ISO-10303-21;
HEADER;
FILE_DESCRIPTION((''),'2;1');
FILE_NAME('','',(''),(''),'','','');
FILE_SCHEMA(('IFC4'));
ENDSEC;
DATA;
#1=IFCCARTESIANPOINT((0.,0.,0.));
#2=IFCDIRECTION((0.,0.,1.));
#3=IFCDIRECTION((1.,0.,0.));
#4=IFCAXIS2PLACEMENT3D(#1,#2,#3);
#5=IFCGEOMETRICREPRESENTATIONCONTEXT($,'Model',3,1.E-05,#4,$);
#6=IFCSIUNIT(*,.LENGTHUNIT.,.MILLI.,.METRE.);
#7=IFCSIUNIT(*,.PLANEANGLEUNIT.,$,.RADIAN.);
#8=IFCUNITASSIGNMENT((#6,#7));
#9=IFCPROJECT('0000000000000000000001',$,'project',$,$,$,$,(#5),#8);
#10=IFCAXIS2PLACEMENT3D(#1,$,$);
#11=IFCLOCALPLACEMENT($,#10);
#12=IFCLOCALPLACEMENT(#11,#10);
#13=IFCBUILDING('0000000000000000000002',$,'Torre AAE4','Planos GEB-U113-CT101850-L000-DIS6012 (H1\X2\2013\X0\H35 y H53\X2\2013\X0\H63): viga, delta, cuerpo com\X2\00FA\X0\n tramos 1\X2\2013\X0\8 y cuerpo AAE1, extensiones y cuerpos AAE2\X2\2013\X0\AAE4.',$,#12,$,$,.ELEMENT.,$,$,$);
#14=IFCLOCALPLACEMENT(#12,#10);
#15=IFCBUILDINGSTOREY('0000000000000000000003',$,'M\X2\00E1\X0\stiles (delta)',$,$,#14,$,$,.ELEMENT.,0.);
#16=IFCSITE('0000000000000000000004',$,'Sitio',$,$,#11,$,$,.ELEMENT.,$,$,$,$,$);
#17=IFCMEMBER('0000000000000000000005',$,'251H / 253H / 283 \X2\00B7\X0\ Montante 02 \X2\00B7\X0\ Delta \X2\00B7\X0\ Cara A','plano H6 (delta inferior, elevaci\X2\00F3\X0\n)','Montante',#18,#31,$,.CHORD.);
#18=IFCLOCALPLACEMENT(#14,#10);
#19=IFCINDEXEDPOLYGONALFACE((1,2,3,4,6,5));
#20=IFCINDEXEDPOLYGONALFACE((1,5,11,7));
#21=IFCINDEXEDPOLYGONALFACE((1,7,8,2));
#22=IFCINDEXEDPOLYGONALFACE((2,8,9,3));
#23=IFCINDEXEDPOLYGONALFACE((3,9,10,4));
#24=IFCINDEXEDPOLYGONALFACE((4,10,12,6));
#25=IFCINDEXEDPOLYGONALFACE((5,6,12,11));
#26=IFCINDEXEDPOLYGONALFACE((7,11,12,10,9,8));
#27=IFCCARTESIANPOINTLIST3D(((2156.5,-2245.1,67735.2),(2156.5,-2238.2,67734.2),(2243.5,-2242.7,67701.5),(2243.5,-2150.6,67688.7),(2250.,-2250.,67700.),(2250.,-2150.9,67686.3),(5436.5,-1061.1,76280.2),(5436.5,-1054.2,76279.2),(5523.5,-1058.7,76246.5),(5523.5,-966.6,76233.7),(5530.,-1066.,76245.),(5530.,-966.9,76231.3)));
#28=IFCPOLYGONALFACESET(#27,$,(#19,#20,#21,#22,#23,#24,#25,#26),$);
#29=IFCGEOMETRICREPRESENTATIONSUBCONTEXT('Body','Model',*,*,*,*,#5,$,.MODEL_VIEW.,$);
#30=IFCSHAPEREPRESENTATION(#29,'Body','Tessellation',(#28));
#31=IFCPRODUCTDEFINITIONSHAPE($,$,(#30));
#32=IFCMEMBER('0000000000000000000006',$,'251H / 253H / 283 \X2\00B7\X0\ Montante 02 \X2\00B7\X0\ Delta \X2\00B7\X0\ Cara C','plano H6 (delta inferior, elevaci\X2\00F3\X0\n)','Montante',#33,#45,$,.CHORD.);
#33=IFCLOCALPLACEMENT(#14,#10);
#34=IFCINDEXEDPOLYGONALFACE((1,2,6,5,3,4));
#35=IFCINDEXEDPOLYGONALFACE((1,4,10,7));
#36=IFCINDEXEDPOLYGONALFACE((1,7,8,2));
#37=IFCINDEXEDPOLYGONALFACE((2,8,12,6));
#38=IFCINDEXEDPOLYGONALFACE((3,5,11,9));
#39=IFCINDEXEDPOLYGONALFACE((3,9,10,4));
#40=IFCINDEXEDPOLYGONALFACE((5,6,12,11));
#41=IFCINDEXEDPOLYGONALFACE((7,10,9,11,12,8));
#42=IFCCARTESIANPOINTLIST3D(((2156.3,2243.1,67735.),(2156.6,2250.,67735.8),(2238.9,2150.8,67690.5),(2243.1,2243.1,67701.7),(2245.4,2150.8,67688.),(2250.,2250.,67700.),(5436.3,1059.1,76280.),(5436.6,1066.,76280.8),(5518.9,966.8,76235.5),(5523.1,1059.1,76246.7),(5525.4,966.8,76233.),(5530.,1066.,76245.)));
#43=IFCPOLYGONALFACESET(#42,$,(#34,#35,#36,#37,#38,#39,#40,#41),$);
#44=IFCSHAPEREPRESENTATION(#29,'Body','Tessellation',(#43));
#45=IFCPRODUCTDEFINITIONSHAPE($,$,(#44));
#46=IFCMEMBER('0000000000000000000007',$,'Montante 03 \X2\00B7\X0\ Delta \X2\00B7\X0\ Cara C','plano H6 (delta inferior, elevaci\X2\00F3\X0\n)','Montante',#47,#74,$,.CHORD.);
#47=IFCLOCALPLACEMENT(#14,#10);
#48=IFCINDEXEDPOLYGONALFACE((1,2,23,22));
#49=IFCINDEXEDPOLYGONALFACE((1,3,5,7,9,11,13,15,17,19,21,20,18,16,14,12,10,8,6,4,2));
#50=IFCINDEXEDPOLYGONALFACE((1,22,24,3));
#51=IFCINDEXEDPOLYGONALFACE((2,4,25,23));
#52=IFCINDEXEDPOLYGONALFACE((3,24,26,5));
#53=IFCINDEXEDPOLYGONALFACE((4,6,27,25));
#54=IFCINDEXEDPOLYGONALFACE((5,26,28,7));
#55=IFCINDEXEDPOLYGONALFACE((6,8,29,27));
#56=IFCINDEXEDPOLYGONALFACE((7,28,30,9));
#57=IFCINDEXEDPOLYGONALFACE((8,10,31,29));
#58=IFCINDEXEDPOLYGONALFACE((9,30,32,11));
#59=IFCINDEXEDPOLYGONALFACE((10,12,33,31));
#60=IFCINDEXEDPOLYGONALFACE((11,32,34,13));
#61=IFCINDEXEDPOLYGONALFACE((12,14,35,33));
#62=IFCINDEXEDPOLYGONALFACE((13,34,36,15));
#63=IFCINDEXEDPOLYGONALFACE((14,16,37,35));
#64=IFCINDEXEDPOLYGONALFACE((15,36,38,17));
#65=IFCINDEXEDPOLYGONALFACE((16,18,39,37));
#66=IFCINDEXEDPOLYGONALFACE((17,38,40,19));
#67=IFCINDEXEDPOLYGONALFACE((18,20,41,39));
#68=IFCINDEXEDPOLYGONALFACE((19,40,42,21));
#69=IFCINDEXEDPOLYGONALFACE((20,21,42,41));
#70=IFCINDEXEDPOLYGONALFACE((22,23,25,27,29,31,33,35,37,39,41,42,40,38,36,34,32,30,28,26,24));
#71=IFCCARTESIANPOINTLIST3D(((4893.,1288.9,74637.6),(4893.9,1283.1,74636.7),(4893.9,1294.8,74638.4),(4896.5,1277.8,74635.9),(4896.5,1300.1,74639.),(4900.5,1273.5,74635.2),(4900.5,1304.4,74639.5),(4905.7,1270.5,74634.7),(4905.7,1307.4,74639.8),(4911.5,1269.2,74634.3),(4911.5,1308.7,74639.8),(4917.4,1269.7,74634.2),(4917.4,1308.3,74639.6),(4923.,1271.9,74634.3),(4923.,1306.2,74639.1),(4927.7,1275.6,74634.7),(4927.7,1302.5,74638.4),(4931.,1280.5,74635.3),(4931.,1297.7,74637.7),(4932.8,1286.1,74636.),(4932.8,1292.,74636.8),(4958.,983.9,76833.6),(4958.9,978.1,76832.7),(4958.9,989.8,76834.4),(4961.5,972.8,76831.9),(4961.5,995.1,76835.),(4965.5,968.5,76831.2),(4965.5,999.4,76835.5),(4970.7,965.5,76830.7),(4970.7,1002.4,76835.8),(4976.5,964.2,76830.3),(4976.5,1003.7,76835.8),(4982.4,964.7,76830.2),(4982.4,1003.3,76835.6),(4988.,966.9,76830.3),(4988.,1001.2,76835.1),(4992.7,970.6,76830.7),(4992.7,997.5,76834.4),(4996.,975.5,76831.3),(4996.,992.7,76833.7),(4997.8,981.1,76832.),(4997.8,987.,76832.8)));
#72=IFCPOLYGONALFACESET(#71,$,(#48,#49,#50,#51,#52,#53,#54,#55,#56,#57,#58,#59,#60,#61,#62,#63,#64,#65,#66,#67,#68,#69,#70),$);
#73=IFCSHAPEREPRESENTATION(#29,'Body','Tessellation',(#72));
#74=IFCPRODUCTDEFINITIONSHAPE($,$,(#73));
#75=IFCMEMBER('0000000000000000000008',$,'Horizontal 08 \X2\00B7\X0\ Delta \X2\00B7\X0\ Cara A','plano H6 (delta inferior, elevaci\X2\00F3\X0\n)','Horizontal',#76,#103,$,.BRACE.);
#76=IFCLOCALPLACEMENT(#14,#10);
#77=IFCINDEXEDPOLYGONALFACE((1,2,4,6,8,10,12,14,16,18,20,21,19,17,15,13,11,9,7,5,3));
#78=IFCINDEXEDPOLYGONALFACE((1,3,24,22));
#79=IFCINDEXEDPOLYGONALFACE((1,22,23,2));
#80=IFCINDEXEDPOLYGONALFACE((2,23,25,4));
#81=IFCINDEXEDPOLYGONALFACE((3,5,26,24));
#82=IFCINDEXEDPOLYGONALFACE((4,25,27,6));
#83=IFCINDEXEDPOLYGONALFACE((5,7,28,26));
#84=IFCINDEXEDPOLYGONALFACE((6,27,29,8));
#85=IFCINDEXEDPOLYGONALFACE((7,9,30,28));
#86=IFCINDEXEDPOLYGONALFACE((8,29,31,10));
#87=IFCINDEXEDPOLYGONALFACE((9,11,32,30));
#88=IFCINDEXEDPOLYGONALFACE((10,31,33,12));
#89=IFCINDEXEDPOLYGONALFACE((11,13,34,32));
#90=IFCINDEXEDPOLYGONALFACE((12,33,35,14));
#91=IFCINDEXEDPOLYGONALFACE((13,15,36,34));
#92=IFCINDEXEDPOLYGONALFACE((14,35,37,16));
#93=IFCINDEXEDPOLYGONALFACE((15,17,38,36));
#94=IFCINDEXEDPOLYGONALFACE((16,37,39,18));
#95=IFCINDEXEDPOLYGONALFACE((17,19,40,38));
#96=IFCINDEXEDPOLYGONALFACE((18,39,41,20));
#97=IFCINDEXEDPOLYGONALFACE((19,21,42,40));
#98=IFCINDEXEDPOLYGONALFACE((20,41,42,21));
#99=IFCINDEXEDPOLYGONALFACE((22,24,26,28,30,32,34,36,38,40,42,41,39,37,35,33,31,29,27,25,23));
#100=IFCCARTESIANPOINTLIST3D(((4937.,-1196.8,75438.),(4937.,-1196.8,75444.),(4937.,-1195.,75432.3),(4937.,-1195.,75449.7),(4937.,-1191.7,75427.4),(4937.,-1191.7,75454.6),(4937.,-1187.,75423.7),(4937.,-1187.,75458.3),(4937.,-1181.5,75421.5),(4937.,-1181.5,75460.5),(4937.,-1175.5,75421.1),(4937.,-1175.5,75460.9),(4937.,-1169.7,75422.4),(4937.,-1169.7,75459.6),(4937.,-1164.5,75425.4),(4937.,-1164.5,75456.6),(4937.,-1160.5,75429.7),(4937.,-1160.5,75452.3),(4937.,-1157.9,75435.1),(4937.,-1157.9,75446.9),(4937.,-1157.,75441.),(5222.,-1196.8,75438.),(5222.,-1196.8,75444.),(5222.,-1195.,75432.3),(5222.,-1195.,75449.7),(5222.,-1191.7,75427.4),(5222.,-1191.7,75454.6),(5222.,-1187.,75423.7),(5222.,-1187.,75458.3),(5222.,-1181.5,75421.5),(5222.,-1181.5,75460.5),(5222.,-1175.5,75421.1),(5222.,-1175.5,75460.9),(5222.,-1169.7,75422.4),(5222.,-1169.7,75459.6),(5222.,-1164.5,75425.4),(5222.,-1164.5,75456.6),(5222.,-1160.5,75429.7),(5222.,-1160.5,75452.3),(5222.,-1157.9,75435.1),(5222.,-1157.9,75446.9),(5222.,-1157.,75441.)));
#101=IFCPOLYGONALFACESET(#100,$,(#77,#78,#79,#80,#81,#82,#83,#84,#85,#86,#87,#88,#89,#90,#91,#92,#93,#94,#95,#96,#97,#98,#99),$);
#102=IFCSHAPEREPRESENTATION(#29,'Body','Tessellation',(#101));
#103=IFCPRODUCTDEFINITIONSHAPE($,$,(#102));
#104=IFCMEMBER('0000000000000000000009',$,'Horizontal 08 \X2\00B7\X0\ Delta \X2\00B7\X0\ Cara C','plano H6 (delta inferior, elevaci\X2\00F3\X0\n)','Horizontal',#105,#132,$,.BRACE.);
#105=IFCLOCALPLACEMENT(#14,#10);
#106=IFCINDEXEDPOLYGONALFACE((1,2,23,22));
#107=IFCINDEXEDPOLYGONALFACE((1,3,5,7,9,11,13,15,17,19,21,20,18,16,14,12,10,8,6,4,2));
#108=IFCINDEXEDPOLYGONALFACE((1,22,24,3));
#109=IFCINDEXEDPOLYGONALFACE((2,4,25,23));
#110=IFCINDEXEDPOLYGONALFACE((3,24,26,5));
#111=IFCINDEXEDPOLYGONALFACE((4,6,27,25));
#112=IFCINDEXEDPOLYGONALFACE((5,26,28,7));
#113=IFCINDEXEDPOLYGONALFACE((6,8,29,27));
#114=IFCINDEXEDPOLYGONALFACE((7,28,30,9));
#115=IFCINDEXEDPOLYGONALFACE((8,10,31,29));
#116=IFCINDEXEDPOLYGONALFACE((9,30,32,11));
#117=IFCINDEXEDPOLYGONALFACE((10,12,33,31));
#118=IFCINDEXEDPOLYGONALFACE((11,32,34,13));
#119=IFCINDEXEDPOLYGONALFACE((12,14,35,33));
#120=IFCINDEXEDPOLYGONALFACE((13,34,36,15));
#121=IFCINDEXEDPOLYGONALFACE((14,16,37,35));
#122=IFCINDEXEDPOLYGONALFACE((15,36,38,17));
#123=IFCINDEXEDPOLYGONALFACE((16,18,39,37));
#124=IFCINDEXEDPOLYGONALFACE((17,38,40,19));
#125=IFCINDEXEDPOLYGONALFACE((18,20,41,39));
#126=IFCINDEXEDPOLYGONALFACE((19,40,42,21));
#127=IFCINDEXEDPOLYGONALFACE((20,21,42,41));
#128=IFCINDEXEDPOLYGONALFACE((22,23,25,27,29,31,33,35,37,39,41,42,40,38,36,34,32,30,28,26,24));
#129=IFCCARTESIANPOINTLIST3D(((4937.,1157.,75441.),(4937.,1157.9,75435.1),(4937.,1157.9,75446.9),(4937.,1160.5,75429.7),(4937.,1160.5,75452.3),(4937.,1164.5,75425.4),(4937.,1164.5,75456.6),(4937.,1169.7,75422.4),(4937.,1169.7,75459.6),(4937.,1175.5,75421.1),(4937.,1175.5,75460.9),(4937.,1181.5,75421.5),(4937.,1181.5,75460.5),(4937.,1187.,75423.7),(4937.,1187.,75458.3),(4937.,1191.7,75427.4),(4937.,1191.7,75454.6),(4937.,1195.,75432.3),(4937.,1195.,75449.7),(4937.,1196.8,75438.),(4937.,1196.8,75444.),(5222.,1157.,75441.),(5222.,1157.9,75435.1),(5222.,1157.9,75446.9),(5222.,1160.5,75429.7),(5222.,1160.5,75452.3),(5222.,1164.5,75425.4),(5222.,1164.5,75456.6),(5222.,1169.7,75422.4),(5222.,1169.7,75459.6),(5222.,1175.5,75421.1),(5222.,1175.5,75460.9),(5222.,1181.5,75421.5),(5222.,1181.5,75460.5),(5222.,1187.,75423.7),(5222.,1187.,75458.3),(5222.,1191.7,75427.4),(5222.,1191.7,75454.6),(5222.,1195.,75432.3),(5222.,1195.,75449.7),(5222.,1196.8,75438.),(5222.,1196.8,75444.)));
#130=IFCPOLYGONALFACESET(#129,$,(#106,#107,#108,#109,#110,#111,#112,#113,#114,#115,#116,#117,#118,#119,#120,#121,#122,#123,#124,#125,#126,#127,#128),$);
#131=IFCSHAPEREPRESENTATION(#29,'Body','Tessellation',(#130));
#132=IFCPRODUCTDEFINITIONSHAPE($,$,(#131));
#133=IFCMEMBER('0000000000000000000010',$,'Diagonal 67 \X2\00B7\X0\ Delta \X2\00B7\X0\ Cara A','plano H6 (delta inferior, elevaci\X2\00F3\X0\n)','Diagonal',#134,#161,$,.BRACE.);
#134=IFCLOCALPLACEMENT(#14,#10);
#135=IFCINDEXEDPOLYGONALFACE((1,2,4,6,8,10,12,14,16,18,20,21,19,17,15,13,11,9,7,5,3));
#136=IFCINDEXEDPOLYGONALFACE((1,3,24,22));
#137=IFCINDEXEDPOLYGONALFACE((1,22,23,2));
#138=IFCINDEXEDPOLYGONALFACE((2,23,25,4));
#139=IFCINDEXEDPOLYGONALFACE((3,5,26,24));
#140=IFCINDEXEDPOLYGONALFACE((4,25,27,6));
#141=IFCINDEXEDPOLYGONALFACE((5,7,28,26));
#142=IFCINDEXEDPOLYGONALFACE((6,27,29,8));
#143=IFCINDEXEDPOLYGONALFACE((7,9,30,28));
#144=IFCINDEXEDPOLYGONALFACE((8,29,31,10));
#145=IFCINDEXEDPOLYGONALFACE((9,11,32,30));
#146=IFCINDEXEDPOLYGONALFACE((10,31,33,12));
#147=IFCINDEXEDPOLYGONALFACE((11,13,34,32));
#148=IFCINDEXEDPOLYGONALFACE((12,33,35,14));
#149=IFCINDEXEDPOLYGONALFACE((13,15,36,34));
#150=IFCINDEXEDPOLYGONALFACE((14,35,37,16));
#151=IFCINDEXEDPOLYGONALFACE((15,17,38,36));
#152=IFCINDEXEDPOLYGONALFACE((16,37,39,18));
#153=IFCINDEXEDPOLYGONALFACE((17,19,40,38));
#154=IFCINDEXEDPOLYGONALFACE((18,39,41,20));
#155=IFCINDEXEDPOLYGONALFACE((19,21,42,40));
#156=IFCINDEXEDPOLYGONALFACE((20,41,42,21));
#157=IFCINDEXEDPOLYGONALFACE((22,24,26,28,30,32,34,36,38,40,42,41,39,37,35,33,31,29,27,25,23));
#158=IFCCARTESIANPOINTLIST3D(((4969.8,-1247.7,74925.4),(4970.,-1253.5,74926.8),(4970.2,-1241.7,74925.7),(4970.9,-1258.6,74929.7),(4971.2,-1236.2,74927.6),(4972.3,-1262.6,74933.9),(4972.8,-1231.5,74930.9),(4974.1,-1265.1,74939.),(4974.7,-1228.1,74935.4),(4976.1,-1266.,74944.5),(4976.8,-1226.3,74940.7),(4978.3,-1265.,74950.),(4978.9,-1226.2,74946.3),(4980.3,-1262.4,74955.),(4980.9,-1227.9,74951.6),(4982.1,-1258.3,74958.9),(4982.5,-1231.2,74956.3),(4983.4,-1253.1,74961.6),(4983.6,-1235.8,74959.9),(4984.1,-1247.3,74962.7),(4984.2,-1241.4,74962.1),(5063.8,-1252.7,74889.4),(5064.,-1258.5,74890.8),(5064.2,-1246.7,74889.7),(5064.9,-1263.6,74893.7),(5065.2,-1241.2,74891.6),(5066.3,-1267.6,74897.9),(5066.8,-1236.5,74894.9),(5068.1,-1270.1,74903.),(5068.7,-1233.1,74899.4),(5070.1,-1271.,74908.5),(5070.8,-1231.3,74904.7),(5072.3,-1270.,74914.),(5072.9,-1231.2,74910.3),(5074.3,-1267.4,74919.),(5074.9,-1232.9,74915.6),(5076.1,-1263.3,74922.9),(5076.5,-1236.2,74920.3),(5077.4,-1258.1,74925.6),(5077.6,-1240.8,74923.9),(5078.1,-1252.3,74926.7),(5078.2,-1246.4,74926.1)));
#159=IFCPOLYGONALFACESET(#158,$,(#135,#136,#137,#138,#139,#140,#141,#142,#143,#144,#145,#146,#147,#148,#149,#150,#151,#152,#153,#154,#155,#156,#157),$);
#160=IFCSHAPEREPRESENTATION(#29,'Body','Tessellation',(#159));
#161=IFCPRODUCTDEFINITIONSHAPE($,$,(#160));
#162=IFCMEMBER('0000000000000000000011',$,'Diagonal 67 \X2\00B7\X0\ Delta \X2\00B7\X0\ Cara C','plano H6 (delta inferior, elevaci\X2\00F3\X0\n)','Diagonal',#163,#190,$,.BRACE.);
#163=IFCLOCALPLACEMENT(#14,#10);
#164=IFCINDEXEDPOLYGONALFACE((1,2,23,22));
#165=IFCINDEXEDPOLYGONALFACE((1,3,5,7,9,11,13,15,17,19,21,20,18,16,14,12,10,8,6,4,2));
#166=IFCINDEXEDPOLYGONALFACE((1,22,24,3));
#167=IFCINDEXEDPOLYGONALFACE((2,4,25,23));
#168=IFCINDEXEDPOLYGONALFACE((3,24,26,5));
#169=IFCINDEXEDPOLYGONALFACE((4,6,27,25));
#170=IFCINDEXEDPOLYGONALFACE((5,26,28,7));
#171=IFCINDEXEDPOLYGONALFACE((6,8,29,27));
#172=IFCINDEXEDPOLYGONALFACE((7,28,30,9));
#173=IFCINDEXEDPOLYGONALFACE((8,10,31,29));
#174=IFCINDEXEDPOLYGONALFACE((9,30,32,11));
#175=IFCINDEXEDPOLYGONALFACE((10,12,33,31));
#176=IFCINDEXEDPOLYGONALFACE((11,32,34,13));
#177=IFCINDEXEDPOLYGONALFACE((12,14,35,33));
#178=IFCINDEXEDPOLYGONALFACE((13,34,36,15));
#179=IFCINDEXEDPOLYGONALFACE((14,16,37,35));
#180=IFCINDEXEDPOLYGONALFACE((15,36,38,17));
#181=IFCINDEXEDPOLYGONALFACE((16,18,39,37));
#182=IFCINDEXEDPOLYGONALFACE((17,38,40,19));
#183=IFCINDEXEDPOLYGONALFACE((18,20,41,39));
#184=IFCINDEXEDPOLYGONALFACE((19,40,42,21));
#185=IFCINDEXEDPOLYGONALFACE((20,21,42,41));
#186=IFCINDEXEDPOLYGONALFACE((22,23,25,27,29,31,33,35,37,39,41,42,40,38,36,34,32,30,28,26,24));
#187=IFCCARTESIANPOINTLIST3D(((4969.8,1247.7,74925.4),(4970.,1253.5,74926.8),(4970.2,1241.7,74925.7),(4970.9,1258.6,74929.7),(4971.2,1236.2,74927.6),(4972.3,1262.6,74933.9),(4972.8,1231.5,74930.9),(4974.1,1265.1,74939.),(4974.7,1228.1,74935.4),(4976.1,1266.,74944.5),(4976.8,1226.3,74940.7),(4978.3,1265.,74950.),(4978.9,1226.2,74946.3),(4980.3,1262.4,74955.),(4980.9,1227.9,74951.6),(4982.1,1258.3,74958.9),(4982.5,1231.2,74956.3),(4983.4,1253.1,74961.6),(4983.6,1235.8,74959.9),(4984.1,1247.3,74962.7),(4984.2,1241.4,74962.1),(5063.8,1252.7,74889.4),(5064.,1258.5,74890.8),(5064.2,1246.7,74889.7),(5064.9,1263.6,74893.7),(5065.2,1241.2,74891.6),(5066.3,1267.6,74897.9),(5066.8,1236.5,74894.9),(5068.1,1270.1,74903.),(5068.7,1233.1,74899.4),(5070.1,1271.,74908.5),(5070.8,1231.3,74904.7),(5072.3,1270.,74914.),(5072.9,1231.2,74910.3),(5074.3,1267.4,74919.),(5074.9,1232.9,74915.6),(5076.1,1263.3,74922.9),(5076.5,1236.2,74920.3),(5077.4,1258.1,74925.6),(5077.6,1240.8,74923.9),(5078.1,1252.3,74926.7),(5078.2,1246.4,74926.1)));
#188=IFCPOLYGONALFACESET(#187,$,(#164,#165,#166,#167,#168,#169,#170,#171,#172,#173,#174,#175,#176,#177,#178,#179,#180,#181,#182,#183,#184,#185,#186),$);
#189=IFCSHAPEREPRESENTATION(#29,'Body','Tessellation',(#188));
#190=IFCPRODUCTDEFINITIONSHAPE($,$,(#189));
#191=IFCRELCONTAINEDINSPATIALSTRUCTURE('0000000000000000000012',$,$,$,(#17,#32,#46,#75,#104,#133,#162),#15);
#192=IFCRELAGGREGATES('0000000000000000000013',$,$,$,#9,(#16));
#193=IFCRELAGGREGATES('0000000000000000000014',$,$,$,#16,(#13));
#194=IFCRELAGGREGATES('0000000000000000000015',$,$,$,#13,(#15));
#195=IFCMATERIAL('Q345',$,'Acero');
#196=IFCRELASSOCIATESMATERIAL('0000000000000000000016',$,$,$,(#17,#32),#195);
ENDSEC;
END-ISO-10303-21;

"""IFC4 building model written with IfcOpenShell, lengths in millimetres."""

from ifc_helpers import new_model, si_unit, frame, frame_2d, origin, origin_with_axes, place, context, subcontext, project, spatial, circle, l_section, extrude, material, element, save


model = new_model("IFC4")

# Units and contexts
model_context = context("Model", 3, precision=1e-05, world=origin_with_axes())
body_context = subcontext(model_context, "Body", "Model", "MODEL_VIEW")
ifc_project = project(units=[si_unit("LENGTHUNIT", "METRE", prefix="MILLI"), si_unit("PLANEANGLEUNIT", "RADIAN")], contexts=[model_context])

# Site, building, storey
site_placement = place(None, origin())
site = spatial("IfcSite", under=ifc_project, at=site_placement, Name="Sitio", CompositionType="ELEMENT")
building_placement = place(site_placement, origin())
building = spatial("IfcBuilding", under=site, at=building_placement, Name="Torre AAE4", Description="Planos GEB-U113-CT101850-L000-DIS6012 (H1–H35 y H53–H63): viga, delta, cuerpo común tramos 1–8 y cuerpo AAE1, extensiones y cuerpos AAE2–AAE4.", CompositionType="ELEMENT")
storey_placement = place(building_placement, origin())
storey = spatial("IfcBuildingStorey", under=building, at=storey_placement, Name="Mástiles (delta)", CompositionType="ELEMENT", Elevation=0.0)

# Members
ifc_material = material(Name="Q345", Category="Acero")
for number, where, z_axis, x_axis, name in (
    (1, (5530.0, -1066.0, 76245.0), (-0.355396, -0.128289, -0.92587), (-0.934716, 0.048778, 0.352032), "251H / 253H / 283 · Montante 02 · Delta · Cara A"),
    (2, (5530.0, 1066.0, 76245.0), (-0.355396, 0.128289, -0.92587), (-0.045973, -0.991737, -0.119769), "251H / 253H / 283 · Montante 02 · Delta · Cara C"),
):
    element("IfcMember", number, at=place(storey_placement, frame(where, z_axis=z_axis, x_axis=x_axis)), inside=storey, material=ifc_material, Name=name, Description="plano H6 (delta inferior, elevación)", ObjectType="Montante", PredefinedType="CHORD", context=body_context, shape_type="SweptSolid", body=[
        extrude(l_section(Depth=100.0, Width=100.0, Thickness=7.0, at=frame_2d((50.0, 50.0))), None, (0.0, 0.0, 1.0), 9229.2),
    ])
member_placement = place(storey_placement, frame((4913.0, 1289.0, 74637.0), z_axis=(0.029305, -0.137509, 0.990067), x_axis=(-0.999571, -0.004031, 0.029027)))
element("IfcMember", 3, at=member_placement, inside=storey, Name="Montante 03 · Delta · Cara C", Description="plano H6 (delta inferior, elevación)", ObjectType="Montante", PredefinedType="CHORD", context=body_context, shape_type="SweptSolid", body=[
    extrude(circle(Radius=20.0), None, (0.0, 0.0, 1.0), 2218.0),
])
for number, where, z_axis, x_axis, name in (
    (4, (4937.0, -1177.0, 75441.0), (1.0, 0.0, 0.0), (0.0, 1.0, 0.0), "Horizontal 08 · Delta · Cara A"),
    (5, (4937.0, 1177.0, 75441.0), (1.0, 0.0, 0.0), (0.0, -1.0, 0.0), "Horizontal 08 · Delta · Cara C"),
):
    element("IfcMember", number, at=place(storey_placement, frame(where, z_axis=z_axis, x_axis=x_axis)), inside=storey, Name=name, Description="plano H6 (delta inferior, elevación)", ObjectType="Horizontal", PredefinedType="BRACE", context=body_context, shape_type="SweptSolid", body=[
        extrude(circle(Radius=20.0), None, (0.0, 0.0, 1.0), 285.0),
    ])
for number, where, z_axis, x_axis, name in (
    (6, (4977.0, -1246.0, 74944.0), (0.932707, -0.049612, -0.357207), (-0.288684, 0.490939, -0.821973), "Diagonal 67 · Delta · Cara A"),
    (7, (4977.0, 1246.0, 74944.0), (0.932707, 0.049612, -0.357207), (-0.288684, -0.490939, -0.821973), "Diagonal 67 · Delta · Cara C"),
):
    element("IfcMember", number, at=place(storey_placement, frame(where, z_axis=z_axis, x_axis=x_axis)), inside=storey, Name=name, Description="plano H6 (delta inferior, elevación)", ObjectType="Diagonal", PredefinedType="BRACE", context=body_context, shape_type="SweptSolid", body=[
        extrude(circle(Radius=20.0), None, (0.0, 0.0, 1.0), 100.8),
    ])

save(model, "model.ifc")
